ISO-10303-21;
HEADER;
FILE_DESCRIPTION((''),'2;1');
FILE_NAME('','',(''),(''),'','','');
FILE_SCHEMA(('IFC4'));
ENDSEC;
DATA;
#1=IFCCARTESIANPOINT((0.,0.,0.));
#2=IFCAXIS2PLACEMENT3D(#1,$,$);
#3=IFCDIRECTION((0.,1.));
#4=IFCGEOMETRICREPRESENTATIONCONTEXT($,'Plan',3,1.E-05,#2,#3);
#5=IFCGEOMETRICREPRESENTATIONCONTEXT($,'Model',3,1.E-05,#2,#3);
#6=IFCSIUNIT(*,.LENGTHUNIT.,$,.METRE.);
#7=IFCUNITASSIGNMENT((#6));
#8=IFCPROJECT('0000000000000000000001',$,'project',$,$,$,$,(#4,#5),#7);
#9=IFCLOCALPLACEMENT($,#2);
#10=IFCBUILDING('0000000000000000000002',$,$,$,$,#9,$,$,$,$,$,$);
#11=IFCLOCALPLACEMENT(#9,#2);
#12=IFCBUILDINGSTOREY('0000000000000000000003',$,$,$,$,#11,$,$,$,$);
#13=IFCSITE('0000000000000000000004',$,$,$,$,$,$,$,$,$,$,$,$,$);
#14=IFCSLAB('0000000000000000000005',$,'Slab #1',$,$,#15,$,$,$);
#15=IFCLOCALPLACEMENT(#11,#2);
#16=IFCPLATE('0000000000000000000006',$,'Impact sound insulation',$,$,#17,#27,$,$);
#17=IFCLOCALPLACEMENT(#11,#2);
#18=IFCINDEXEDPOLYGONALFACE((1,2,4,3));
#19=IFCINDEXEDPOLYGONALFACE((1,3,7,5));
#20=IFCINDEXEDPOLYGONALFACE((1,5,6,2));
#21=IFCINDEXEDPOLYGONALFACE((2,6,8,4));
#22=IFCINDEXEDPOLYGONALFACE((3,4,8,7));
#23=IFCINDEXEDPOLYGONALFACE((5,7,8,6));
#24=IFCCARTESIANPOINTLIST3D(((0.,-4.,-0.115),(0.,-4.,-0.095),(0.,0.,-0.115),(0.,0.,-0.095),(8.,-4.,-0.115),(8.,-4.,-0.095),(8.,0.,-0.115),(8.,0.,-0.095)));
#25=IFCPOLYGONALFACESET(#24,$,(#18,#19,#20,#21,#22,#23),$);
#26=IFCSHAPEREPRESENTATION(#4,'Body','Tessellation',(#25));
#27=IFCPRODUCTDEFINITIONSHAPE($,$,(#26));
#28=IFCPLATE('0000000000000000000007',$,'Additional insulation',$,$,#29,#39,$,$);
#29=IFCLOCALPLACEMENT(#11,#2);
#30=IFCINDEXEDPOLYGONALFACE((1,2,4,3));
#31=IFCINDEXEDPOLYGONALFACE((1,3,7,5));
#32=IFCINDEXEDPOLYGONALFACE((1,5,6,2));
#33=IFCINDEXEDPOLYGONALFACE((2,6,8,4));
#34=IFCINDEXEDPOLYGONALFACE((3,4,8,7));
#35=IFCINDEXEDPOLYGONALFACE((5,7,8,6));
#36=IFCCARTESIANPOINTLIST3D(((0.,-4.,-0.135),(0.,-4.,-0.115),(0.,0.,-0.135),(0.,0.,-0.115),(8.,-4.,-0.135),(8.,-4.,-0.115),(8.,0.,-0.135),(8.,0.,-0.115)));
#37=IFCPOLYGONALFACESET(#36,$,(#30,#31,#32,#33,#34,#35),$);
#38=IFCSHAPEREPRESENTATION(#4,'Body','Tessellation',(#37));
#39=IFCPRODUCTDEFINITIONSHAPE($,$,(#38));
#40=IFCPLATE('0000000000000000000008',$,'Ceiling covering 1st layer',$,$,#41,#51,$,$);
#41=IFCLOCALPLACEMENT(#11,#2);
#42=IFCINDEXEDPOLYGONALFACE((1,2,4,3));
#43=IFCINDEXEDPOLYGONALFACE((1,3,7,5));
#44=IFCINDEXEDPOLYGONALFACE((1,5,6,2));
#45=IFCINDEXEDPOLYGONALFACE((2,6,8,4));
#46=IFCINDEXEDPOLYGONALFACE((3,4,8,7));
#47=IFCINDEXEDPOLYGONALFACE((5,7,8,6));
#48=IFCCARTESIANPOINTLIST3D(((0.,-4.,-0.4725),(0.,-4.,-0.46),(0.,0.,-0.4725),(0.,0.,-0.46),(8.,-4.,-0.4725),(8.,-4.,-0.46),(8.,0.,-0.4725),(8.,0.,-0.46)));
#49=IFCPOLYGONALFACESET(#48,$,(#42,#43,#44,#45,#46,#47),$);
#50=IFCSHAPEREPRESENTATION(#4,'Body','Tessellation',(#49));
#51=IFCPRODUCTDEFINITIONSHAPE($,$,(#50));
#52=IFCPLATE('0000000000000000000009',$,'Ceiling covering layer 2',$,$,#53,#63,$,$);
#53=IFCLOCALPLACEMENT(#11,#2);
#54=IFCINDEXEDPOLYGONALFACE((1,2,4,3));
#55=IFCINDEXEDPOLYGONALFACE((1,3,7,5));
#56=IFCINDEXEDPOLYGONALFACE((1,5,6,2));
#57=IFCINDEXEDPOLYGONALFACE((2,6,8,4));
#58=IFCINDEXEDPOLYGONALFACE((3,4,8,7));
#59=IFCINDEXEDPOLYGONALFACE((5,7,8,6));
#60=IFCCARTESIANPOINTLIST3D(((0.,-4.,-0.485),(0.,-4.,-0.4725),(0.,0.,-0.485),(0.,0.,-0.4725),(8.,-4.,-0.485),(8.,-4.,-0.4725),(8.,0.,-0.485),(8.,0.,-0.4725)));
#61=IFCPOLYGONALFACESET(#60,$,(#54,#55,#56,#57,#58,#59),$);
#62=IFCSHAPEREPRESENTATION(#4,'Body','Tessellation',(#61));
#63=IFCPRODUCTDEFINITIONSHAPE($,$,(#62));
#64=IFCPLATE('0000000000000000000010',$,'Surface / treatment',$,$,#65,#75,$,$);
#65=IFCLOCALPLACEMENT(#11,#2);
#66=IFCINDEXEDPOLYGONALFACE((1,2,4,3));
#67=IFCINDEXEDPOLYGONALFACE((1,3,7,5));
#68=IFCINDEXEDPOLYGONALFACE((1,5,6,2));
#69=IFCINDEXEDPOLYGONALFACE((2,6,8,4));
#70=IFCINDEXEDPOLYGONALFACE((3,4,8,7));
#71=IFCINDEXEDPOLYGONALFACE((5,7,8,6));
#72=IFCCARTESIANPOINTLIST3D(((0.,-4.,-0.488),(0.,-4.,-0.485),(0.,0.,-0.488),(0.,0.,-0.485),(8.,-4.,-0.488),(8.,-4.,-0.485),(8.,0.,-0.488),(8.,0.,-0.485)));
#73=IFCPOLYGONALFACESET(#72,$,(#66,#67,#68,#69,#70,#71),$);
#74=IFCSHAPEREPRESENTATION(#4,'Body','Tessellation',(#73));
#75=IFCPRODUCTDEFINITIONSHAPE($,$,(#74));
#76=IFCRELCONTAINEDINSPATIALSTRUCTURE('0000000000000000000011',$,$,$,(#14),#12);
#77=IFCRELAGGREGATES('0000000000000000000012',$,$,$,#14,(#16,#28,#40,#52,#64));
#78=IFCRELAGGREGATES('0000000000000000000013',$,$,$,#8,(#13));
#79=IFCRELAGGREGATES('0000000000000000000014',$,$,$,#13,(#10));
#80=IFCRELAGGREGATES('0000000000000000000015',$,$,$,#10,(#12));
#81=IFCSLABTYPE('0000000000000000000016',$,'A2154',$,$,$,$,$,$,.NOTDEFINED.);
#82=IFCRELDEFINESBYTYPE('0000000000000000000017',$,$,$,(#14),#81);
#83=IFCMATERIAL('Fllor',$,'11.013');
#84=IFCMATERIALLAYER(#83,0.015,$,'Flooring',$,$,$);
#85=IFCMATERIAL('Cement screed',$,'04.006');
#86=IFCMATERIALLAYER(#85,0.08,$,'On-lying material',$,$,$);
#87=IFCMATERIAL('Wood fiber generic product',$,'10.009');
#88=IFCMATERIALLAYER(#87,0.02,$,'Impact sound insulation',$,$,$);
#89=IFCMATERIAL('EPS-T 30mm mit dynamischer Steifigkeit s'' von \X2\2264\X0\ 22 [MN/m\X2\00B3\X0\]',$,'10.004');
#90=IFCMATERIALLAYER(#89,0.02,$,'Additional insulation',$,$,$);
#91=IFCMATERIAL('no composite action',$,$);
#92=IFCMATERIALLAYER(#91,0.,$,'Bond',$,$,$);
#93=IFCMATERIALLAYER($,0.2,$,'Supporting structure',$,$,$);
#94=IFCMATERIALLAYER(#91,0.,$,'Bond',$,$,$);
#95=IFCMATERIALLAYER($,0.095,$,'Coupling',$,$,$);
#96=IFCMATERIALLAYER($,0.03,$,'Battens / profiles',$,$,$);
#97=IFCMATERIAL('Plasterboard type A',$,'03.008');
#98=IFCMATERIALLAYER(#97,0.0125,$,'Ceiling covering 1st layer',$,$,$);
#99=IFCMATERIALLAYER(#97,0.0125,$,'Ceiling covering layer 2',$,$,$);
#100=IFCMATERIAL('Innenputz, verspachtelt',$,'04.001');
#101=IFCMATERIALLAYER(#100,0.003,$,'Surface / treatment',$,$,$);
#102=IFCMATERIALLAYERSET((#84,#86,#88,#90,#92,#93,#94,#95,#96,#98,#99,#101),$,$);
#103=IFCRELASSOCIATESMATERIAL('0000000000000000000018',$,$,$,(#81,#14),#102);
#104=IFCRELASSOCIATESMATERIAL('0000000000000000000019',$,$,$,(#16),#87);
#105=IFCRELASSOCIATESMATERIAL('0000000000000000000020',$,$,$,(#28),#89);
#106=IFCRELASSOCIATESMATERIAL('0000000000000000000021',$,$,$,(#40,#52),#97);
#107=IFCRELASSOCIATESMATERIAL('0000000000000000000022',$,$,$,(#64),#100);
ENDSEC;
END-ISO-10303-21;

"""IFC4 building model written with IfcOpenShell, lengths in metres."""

from ifc_helpers import new_model, si_unit, direction, frame, frame_2d, origin, place, context, project, spatial, rectangle, extrude, material, layer, layer_set, type_object, element, aggregate, save


model = new_model("IFC4")

# Units and contexts
plan_context = context("Plan", 3, precision=1e-05, world=origin(), true_north=direction((0.0, 1.0)))
model_context = context("Model", 3, precision=1e-05, world=origin(), true_north=direction((0.0, 1.0)))
ifc_project = project(units=[si_unit("LENGTHUNIT", "METRE")], contexts=[plan_context, model_context])

# Site, building, storey
site = spatial("IfcSite", under=ifc_project)
building_placement = place(None, origin())
building = spatial("IfcBuilding", under=site, at=building_placement)
storey_placement = place(building_placement, origin())
storey = spatial("IfcBuildingStorey", under=building, at=storey_placement)

# Slab, plates
ifc_material_1 = material(Name="Fllor", Category="11.013")
ifc_layer_1 = layer(ifc_material_1, 0.015, Name="Flooring")
ifc_material_2 = material(Name="Cement screed", Category="04.006")
ifc_layer_2 = layer(ifc_material_2, 0.08, Name="On-lying material")
ifc_material_3 = material(Name="Wood fiber generic product", Category="10.009")
ifc_layer_3 = layer(ifc_material_3, 0.02, Name="Impact sound insulation")
ifc_material_4 = material(Name="EPS-T 30mm mit dynamischer Steifigkeit s' von ≤ 22 [MN/m³]", Category="10.004")
ifc_layer_4 = layer(ifc_material_4, 0.02, Name="Additional insulation")
ifc_material_5 = material(Name="no composite action")
ifc_layer_5 = layer(ifc_material_5, 0.0, Name="Bond")
ifc_layer_6 = layer(None, 0.2, Name="Supporting structure")
ifc_layer_7 = layer(ifc_material_5, 0.0, Name="Bond")
ifc_layer_8 = layer(None, 0.095, Name="Coupling")
ifc_layer_9 = layer(None, 0.03, Name="Battens / profiles")
ifc_material_6 = material(Name="Plasterboard type A", Category="03.008")
ifc_layer_10 = layer(ifc_material_6, 0.0125, Name="Ceiling covering 1st layer")
ifc_layer_11 = layer(ifc_material_6, 0.0125, Name="Ceiling covering layer 2")
ifc_material_7 = material(Name="Innenputz, verspachtelt", Category="04.001")
ifc_layer_12 = layer(ifc_material_7, 0.003, Name="Surface / treatment")
ifc_layer_set = layer_set([ifc_layer_1, ifc_layer_2, ifc_layer_3, ifc_layer_4, ifc_layer_5, ifc_layer_6, ifc_layer_7, ifc_layer_8, ifc_layer_9, ifc_layer_10, ifc_layer_11, ifc_layer_12])
slab_type = type_object("IfcSlabType", Name="A2154", PredefinedType="NOTDEFINED", material=ifc_layer_set)
slab_placement = place(None, frame((0.0, 0.0, 0.0), z_axis=(0.0, 0.0, -1.0), x_axis=(1.0, 0.0, 0.0)))
slab = element("IfcSlab", 1, at=slab_placement, inside=storey, type_object=slab_type, material=ifc_layer_set, Name="Slab #1")
plate_1_placement = place(slab_placement, origin())
plate_1 = element("IfcPlate", 2, at=plate_1_placement, material=ifc_material_3, Name="Impact sound insulation", context=plan_context, shape_type="SweptSolid", body=[
    extrude(rectangle(XDim=8.0, YDim=4.0, at=frame_2d((4.0, 2.0), x_axis=(1.0, 0.0))), frame((0.0, 0.0, 0.095), z_axis=(0.0, 0.0, 1.0), x_axis=(1.0, 0.0, 0.0)), (0.0, 0.0, 1.0), 0.02),
])
plate_2_placement = place(slab_placement, origin())
plate_2 = element("IfcPlate", 3, at=plate_2_placement, material=ifc_material_4, Name="Additional insulation", context=plan_context, shape_type="SweptSolid", body=[
    extrude(rectangle(XDim=8.0, YDim=4.0, at=frame_2d((4.0, 2.0), x_axis=(1.0, 0.0))), frame((0.0, 0.0, 0.115), z_axis=(0.0, 0.0, 1.0), x_axis=(1.0, 0.0, 0.0)), (0.0, 0.0, 1.0), 0.02),
])
plate_3_placement = place(slab_placement, origin())
plate_3 = element("IfcPlate", 4, at=plate_3_placement, material=ifc_material_6, Name="Ceiling covering 1st layer", context=plan_context, shape_type="SweptSolid", body=[
    extrude(rectangle(XDim=8.0, YDim=4.0, at=frame_2d((4.0, 2.0), x_axis=(1.0, 0.0))), frame((0.0, 0.0, 0.46), z_axis=(0.0, 0.0, 1.0), x_axis=(1.0, 0.0, 0.0)), (0.0, 0.0, 1.0), 0.0125),
])
plate_4_placement = place(slab_placement, origin())
plate_4 = element("IfcPlate", 5, at=plate_4_placement, material=ifc_material_6, Name="Ceiling covering layer 2", context=plan_context, shape_type="SweptSolid", body=[
    extrude(rectangle(XDim=8.0, YDim=4.0, at=frame_2d((4.0, 2.0), x_axis=(1.0, 0.0))), frame((0.0, 0.0, 0.4725), z_axis=(0.0, 0.0, 1.0), x_axis=(1.0, 0.0, 0.0)), (0.0, 0.0, 1.0), 0.0125),
])
plate_5_placement = place(slab_placement, origin())
plate_5 = element("IfcPlate", 6, at=plate_5_placement, material=ifc_material_7, Name="Surface / treatment", context=plan_context, shape_type="SweptSolid", body=[
    extrude(rectangle(XDim=8.0, YDim=4.0, at=frame_2d((4.0, 2.0), x_axis=(1.0, 0.0))), frame((0.0, 0.0, 0.485), z_axis=(0.0, 0.0, 1.0), x_axis=(1.0, 0.0, 0.0)), (0.0, 0.0, 1.0), 0.003),
])
aggregate(slab, [plate_1, plate_2, plate_3, plate_4, plate_5])

save(model, "model.ifc")
